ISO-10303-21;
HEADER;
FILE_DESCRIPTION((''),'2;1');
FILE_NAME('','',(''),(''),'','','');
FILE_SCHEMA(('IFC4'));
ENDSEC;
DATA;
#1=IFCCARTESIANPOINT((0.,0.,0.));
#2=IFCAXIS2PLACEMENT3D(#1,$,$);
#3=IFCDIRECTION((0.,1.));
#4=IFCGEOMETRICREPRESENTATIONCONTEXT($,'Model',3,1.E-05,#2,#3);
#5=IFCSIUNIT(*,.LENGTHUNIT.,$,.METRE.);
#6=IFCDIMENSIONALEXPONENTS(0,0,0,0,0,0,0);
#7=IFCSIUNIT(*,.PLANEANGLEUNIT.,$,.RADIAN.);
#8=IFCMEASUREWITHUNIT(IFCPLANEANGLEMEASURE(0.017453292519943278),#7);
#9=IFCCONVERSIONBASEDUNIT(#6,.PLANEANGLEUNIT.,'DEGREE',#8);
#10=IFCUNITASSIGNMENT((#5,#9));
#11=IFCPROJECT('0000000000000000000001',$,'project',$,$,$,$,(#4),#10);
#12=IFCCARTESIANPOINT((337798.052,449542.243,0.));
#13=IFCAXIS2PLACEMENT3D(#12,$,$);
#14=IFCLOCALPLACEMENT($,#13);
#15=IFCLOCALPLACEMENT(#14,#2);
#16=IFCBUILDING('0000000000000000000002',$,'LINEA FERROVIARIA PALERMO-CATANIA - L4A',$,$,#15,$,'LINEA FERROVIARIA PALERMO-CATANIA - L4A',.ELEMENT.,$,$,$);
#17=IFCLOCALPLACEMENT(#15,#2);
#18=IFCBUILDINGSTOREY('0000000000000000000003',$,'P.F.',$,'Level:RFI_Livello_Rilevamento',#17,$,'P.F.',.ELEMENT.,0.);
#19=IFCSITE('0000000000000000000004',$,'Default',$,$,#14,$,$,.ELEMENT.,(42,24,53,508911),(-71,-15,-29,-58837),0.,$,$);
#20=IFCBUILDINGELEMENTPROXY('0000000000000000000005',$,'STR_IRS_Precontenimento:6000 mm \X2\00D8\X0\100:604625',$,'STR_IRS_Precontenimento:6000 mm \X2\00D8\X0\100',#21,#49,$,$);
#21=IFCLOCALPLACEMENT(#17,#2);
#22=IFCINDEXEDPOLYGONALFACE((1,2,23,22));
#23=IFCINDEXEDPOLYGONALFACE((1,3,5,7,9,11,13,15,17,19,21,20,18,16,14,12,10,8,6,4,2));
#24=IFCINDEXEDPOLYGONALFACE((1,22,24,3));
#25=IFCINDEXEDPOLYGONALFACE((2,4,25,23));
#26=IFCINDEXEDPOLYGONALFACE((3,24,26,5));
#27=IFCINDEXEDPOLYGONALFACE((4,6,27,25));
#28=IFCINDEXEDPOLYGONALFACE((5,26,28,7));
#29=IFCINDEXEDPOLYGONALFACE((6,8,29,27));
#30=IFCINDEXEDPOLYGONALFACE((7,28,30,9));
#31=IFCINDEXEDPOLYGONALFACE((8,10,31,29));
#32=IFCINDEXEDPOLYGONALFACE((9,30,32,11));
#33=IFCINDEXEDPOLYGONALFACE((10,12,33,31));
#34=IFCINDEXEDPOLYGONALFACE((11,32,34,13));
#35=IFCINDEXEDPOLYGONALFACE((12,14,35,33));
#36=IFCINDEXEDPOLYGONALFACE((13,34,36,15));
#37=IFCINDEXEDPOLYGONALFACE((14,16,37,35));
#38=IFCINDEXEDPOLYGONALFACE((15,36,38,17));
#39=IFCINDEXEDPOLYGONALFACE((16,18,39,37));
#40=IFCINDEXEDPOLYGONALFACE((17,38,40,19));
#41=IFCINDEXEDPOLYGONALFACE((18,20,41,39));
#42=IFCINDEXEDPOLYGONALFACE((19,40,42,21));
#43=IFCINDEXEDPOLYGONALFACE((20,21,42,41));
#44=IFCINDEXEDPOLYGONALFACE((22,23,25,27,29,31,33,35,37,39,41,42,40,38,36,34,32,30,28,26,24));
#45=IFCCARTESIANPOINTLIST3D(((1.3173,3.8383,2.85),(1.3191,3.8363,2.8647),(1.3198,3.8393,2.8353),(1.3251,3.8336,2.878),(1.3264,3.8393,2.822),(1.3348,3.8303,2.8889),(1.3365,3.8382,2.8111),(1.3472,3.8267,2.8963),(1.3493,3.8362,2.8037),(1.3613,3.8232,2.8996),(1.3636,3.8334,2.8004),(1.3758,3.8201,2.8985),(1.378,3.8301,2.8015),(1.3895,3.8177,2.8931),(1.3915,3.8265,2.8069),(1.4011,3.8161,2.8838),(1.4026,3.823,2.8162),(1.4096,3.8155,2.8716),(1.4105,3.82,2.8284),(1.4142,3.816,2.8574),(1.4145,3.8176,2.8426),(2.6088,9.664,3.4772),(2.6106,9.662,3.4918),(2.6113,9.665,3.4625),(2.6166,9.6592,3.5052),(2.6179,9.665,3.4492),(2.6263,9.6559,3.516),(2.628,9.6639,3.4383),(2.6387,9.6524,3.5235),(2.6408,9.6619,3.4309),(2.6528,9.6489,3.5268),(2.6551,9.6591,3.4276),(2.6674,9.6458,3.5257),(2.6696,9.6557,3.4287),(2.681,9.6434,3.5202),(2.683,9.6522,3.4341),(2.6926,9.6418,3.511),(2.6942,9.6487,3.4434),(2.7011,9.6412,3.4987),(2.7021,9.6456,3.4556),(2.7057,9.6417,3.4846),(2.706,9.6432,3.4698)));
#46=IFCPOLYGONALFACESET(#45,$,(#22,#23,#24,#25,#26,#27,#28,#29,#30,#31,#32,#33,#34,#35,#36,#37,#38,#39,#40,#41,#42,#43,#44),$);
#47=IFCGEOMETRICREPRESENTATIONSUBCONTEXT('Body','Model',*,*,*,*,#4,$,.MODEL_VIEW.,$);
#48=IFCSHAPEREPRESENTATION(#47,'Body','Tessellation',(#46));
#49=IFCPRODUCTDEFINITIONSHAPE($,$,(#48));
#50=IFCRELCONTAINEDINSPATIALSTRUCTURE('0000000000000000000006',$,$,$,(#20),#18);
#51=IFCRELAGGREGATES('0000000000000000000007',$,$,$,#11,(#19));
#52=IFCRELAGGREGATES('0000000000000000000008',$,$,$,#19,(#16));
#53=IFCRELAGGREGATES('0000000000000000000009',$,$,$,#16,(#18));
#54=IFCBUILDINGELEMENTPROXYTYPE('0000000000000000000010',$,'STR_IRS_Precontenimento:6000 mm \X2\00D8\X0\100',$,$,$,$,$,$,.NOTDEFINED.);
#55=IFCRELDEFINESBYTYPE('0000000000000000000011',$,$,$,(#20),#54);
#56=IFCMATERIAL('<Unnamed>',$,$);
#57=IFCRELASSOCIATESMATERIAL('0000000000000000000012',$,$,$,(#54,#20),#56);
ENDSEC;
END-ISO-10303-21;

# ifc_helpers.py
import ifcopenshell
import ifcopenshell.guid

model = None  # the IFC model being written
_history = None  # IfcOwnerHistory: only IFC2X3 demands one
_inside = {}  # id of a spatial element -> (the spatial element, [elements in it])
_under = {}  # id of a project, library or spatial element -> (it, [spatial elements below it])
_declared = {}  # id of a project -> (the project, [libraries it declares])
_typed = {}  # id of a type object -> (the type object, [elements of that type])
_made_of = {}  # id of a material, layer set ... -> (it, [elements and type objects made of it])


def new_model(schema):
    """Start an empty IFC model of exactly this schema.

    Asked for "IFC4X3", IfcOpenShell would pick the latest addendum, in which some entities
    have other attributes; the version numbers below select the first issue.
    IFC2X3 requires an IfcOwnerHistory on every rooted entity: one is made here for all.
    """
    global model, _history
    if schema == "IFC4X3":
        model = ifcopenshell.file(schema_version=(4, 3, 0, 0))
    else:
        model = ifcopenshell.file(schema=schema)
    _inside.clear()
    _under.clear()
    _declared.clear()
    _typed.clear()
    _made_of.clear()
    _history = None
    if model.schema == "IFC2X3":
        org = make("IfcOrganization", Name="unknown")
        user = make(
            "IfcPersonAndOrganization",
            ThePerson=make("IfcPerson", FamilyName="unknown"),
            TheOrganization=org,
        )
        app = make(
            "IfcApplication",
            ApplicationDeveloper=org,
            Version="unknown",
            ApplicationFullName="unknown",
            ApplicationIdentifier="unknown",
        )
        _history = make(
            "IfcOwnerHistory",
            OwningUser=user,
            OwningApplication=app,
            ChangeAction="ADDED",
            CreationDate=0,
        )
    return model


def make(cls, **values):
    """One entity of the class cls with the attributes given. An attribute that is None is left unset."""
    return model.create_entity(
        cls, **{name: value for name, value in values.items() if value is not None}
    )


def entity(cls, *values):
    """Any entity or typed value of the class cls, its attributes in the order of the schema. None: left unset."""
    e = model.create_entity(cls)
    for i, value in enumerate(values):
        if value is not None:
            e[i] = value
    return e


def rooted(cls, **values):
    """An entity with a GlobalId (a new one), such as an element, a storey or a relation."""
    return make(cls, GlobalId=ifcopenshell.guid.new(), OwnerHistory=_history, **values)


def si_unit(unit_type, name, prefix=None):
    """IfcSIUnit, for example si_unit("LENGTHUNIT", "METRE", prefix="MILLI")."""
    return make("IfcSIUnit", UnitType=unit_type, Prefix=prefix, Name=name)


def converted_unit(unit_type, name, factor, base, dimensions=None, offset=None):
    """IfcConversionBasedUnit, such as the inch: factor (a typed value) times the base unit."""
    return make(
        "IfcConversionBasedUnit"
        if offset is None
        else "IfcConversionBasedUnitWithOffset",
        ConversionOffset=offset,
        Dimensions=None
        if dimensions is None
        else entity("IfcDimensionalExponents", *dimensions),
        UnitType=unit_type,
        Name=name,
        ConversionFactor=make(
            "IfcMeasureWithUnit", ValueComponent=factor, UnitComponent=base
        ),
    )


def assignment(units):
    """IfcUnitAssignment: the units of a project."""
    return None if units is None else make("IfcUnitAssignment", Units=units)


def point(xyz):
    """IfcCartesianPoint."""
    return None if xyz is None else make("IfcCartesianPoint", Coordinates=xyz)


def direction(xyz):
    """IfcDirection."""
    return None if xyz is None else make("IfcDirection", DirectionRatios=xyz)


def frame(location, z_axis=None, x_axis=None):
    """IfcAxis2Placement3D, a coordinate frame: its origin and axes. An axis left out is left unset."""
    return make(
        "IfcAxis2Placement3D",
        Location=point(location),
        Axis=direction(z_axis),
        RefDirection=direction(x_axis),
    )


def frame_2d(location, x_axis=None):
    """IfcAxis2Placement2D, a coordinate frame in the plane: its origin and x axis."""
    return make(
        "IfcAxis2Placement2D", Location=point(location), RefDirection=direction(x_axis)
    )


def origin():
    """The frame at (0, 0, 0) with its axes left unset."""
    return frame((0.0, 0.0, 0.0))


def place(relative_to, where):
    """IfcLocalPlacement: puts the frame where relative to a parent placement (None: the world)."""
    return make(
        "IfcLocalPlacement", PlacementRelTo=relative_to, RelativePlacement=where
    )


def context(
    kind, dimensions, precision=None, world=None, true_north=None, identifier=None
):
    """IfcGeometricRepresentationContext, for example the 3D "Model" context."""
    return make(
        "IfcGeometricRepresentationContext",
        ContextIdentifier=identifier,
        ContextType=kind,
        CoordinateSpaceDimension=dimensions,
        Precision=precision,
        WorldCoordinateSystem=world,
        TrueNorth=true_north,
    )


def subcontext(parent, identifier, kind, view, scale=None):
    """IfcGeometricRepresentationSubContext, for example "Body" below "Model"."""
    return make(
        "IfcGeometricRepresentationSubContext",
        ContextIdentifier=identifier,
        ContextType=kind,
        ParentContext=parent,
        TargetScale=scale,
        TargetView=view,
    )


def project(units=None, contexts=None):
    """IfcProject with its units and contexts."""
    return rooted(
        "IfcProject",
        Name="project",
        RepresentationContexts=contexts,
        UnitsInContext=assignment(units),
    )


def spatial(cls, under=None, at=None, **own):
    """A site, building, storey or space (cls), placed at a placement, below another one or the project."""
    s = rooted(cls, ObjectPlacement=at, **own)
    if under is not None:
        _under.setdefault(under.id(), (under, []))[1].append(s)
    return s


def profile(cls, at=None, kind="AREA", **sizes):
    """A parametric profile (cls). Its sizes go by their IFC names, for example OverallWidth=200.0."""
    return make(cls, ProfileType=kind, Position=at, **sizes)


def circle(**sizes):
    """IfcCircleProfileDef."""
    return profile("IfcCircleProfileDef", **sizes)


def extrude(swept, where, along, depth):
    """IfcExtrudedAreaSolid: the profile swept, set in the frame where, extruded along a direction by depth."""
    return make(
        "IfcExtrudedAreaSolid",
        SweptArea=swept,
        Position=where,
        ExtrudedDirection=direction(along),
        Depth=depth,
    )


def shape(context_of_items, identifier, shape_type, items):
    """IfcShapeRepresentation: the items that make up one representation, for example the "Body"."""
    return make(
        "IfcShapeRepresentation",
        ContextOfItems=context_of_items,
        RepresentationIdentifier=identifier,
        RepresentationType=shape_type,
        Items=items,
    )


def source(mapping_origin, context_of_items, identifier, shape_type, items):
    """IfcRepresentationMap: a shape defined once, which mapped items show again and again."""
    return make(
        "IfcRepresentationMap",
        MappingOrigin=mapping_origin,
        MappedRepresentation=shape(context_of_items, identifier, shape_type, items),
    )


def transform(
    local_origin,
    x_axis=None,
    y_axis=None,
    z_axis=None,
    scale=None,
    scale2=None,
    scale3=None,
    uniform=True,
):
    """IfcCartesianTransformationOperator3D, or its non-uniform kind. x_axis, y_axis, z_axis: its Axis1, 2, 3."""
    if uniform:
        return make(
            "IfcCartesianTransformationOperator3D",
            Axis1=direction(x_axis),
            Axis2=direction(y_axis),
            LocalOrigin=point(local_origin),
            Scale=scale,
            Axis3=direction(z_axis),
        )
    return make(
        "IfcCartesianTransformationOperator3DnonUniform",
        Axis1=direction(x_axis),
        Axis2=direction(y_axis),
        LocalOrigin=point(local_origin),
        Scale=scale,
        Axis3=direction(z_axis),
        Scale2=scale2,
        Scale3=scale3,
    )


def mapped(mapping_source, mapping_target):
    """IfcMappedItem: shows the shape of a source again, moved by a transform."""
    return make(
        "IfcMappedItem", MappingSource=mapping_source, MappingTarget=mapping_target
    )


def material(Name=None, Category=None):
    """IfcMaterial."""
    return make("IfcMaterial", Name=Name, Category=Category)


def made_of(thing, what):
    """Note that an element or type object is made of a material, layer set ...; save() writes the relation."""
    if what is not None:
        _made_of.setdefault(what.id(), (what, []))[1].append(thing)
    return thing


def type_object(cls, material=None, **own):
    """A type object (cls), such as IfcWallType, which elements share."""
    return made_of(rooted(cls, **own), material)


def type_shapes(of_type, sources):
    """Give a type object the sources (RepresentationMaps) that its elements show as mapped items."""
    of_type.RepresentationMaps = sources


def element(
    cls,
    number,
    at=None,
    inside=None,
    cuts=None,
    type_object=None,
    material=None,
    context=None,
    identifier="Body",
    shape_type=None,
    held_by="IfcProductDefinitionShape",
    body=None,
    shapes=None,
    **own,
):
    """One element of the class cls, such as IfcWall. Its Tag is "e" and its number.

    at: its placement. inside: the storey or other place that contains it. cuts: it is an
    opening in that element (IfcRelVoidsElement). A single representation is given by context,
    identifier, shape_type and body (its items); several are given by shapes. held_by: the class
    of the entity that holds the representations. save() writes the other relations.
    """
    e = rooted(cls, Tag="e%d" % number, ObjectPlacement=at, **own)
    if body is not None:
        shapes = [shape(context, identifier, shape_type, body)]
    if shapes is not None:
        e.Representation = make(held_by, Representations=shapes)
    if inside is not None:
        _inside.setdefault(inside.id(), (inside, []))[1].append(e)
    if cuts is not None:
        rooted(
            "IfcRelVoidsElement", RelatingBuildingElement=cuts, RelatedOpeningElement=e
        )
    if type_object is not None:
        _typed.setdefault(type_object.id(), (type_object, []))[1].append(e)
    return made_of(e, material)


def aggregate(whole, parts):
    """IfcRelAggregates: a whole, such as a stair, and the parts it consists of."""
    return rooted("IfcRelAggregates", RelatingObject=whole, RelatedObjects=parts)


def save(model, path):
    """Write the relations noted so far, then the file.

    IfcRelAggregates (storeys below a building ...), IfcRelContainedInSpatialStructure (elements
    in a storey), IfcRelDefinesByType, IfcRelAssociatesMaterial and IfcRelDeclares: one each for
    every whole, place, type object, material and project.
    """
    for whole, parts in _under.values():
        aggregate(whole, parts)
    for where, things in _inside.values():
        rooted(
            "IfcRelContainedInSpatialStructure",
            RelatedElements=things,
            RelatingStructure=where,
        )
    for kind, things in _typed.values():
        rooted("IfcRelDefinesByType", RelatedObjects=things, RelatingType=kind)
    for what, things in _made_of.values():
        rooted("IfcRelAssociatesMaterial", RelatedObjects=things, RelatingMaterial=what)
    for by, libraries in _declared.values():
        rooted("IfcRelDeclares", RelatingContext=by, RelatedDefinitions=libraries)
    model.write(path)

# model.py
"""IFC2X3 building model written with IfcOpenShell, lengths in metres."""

from ifc_helpers import new_model, entity, si_unit, converted_unit, direction, frame, frame_2d, origin, place, context, subcontext, project, spatial, circle, extrude, source, transform, mapped, material, type_object, type_shapes, element, save


model = new_model("IFC2X3")

# Units and contexts
model_context = context("Model", 3, precision=1e-05, world=origin(), true_north=direction((0.0, 1.0)))
body_context = subcontext(model_context, "Body", "Model", "MODEL_VIEW")
ifc_project = project(units=[si_unit("LENGTHUNIT", "METRE"), converted_unit("PLANEANGLEUNIT", "DEGREE", entity("IfcPlaneAngleMeasure", 0.017453292519943278), si_unit("PLANEANGLEUNIT", "RADIAN"), dimensions=[0, 0, 0, 0, 0, 0, 0])], contexts=[model_context])

# Site, building, storey
site_placement = place(None, frame((337798.052, 449542.243, 0.0)))
site = spatial("IfcSite", under=ifc_project, at=site_placement, Name="Default", CompositionType="ELEMENT", RefLatitude=(42, 24, 53, 508911), RefLongitude=(-71, -15, -29, -58837), RefElevation=0.0)
building_placement = place(site_placement, origin())
building = spatial("IfcBuilding", under=site, at=building_placement, Name="LINEA FERROVIARIA PALERMO-CATANIA - L4A", LongName="LINEA FERROVIARIA PALERMO-CATANIA - L4A", CompositionType="ELEMENT")
storey_placement = place(building_placement, origin())
storey = spatial("IfcBuildingStorey", under=building, at=storey_placement, Name="P.F.", ObjectType="Level:RFI_Livello_Rilevamento", LongName="P.F.", CompositionType="ELEMENT", Elevation=0.0)

# Shared definitions
ifc_material = material(Name="<Unnamed>")

# Building element proxy
building_element_proxy_type_1 = type_object("IfcBuildingElementProxyType", Name="STR_IRS_Precontenimento:6000 mm Ø100", PredefinedType="NOTDEFINED", material=ifc_material)
shared_shape_1 = source(origin(), body_context, "Body", "SweptSolid", [
    extrude(circle(Radius=0.05, at=frame_2d((0.0, 0.0), x_axis=(1.0, 0.0))), frame((0.0, 0.0, -6.0)), (0.0, 0.0, 1.0), 6.0),
])
type_shapes(building_element_proxy_type_1, [shared_shape_1])
for number, where, z_axis, x_axis, name in (
    (1, (1.3661, 3.8275, 2.85), (-0.215254, -0.970948, -0.104528), (-0.976296, 0.21644, 0.0), "STR_IRS_Precontenimento:6000 mm Ø100:604625"),
):
    element("IfcBuildingElementProxy", number, at=place(storey_placement, frame(where, z_axis=z_axis, x_axis=x_axis)), inside=storey, type_object=building_element_proxy_type_1, material=ifc_material, Name=name, ObjectType="STR_IRS_Precontenimento:6000 mm Ø100", context=body_context, shape_type="MappedRepresentation", body=[
        mapped(shared_shape_1, transform((0.0, 0.0, 0.0), scale=1.0)),
    ])

save(model, "model.ifc")
